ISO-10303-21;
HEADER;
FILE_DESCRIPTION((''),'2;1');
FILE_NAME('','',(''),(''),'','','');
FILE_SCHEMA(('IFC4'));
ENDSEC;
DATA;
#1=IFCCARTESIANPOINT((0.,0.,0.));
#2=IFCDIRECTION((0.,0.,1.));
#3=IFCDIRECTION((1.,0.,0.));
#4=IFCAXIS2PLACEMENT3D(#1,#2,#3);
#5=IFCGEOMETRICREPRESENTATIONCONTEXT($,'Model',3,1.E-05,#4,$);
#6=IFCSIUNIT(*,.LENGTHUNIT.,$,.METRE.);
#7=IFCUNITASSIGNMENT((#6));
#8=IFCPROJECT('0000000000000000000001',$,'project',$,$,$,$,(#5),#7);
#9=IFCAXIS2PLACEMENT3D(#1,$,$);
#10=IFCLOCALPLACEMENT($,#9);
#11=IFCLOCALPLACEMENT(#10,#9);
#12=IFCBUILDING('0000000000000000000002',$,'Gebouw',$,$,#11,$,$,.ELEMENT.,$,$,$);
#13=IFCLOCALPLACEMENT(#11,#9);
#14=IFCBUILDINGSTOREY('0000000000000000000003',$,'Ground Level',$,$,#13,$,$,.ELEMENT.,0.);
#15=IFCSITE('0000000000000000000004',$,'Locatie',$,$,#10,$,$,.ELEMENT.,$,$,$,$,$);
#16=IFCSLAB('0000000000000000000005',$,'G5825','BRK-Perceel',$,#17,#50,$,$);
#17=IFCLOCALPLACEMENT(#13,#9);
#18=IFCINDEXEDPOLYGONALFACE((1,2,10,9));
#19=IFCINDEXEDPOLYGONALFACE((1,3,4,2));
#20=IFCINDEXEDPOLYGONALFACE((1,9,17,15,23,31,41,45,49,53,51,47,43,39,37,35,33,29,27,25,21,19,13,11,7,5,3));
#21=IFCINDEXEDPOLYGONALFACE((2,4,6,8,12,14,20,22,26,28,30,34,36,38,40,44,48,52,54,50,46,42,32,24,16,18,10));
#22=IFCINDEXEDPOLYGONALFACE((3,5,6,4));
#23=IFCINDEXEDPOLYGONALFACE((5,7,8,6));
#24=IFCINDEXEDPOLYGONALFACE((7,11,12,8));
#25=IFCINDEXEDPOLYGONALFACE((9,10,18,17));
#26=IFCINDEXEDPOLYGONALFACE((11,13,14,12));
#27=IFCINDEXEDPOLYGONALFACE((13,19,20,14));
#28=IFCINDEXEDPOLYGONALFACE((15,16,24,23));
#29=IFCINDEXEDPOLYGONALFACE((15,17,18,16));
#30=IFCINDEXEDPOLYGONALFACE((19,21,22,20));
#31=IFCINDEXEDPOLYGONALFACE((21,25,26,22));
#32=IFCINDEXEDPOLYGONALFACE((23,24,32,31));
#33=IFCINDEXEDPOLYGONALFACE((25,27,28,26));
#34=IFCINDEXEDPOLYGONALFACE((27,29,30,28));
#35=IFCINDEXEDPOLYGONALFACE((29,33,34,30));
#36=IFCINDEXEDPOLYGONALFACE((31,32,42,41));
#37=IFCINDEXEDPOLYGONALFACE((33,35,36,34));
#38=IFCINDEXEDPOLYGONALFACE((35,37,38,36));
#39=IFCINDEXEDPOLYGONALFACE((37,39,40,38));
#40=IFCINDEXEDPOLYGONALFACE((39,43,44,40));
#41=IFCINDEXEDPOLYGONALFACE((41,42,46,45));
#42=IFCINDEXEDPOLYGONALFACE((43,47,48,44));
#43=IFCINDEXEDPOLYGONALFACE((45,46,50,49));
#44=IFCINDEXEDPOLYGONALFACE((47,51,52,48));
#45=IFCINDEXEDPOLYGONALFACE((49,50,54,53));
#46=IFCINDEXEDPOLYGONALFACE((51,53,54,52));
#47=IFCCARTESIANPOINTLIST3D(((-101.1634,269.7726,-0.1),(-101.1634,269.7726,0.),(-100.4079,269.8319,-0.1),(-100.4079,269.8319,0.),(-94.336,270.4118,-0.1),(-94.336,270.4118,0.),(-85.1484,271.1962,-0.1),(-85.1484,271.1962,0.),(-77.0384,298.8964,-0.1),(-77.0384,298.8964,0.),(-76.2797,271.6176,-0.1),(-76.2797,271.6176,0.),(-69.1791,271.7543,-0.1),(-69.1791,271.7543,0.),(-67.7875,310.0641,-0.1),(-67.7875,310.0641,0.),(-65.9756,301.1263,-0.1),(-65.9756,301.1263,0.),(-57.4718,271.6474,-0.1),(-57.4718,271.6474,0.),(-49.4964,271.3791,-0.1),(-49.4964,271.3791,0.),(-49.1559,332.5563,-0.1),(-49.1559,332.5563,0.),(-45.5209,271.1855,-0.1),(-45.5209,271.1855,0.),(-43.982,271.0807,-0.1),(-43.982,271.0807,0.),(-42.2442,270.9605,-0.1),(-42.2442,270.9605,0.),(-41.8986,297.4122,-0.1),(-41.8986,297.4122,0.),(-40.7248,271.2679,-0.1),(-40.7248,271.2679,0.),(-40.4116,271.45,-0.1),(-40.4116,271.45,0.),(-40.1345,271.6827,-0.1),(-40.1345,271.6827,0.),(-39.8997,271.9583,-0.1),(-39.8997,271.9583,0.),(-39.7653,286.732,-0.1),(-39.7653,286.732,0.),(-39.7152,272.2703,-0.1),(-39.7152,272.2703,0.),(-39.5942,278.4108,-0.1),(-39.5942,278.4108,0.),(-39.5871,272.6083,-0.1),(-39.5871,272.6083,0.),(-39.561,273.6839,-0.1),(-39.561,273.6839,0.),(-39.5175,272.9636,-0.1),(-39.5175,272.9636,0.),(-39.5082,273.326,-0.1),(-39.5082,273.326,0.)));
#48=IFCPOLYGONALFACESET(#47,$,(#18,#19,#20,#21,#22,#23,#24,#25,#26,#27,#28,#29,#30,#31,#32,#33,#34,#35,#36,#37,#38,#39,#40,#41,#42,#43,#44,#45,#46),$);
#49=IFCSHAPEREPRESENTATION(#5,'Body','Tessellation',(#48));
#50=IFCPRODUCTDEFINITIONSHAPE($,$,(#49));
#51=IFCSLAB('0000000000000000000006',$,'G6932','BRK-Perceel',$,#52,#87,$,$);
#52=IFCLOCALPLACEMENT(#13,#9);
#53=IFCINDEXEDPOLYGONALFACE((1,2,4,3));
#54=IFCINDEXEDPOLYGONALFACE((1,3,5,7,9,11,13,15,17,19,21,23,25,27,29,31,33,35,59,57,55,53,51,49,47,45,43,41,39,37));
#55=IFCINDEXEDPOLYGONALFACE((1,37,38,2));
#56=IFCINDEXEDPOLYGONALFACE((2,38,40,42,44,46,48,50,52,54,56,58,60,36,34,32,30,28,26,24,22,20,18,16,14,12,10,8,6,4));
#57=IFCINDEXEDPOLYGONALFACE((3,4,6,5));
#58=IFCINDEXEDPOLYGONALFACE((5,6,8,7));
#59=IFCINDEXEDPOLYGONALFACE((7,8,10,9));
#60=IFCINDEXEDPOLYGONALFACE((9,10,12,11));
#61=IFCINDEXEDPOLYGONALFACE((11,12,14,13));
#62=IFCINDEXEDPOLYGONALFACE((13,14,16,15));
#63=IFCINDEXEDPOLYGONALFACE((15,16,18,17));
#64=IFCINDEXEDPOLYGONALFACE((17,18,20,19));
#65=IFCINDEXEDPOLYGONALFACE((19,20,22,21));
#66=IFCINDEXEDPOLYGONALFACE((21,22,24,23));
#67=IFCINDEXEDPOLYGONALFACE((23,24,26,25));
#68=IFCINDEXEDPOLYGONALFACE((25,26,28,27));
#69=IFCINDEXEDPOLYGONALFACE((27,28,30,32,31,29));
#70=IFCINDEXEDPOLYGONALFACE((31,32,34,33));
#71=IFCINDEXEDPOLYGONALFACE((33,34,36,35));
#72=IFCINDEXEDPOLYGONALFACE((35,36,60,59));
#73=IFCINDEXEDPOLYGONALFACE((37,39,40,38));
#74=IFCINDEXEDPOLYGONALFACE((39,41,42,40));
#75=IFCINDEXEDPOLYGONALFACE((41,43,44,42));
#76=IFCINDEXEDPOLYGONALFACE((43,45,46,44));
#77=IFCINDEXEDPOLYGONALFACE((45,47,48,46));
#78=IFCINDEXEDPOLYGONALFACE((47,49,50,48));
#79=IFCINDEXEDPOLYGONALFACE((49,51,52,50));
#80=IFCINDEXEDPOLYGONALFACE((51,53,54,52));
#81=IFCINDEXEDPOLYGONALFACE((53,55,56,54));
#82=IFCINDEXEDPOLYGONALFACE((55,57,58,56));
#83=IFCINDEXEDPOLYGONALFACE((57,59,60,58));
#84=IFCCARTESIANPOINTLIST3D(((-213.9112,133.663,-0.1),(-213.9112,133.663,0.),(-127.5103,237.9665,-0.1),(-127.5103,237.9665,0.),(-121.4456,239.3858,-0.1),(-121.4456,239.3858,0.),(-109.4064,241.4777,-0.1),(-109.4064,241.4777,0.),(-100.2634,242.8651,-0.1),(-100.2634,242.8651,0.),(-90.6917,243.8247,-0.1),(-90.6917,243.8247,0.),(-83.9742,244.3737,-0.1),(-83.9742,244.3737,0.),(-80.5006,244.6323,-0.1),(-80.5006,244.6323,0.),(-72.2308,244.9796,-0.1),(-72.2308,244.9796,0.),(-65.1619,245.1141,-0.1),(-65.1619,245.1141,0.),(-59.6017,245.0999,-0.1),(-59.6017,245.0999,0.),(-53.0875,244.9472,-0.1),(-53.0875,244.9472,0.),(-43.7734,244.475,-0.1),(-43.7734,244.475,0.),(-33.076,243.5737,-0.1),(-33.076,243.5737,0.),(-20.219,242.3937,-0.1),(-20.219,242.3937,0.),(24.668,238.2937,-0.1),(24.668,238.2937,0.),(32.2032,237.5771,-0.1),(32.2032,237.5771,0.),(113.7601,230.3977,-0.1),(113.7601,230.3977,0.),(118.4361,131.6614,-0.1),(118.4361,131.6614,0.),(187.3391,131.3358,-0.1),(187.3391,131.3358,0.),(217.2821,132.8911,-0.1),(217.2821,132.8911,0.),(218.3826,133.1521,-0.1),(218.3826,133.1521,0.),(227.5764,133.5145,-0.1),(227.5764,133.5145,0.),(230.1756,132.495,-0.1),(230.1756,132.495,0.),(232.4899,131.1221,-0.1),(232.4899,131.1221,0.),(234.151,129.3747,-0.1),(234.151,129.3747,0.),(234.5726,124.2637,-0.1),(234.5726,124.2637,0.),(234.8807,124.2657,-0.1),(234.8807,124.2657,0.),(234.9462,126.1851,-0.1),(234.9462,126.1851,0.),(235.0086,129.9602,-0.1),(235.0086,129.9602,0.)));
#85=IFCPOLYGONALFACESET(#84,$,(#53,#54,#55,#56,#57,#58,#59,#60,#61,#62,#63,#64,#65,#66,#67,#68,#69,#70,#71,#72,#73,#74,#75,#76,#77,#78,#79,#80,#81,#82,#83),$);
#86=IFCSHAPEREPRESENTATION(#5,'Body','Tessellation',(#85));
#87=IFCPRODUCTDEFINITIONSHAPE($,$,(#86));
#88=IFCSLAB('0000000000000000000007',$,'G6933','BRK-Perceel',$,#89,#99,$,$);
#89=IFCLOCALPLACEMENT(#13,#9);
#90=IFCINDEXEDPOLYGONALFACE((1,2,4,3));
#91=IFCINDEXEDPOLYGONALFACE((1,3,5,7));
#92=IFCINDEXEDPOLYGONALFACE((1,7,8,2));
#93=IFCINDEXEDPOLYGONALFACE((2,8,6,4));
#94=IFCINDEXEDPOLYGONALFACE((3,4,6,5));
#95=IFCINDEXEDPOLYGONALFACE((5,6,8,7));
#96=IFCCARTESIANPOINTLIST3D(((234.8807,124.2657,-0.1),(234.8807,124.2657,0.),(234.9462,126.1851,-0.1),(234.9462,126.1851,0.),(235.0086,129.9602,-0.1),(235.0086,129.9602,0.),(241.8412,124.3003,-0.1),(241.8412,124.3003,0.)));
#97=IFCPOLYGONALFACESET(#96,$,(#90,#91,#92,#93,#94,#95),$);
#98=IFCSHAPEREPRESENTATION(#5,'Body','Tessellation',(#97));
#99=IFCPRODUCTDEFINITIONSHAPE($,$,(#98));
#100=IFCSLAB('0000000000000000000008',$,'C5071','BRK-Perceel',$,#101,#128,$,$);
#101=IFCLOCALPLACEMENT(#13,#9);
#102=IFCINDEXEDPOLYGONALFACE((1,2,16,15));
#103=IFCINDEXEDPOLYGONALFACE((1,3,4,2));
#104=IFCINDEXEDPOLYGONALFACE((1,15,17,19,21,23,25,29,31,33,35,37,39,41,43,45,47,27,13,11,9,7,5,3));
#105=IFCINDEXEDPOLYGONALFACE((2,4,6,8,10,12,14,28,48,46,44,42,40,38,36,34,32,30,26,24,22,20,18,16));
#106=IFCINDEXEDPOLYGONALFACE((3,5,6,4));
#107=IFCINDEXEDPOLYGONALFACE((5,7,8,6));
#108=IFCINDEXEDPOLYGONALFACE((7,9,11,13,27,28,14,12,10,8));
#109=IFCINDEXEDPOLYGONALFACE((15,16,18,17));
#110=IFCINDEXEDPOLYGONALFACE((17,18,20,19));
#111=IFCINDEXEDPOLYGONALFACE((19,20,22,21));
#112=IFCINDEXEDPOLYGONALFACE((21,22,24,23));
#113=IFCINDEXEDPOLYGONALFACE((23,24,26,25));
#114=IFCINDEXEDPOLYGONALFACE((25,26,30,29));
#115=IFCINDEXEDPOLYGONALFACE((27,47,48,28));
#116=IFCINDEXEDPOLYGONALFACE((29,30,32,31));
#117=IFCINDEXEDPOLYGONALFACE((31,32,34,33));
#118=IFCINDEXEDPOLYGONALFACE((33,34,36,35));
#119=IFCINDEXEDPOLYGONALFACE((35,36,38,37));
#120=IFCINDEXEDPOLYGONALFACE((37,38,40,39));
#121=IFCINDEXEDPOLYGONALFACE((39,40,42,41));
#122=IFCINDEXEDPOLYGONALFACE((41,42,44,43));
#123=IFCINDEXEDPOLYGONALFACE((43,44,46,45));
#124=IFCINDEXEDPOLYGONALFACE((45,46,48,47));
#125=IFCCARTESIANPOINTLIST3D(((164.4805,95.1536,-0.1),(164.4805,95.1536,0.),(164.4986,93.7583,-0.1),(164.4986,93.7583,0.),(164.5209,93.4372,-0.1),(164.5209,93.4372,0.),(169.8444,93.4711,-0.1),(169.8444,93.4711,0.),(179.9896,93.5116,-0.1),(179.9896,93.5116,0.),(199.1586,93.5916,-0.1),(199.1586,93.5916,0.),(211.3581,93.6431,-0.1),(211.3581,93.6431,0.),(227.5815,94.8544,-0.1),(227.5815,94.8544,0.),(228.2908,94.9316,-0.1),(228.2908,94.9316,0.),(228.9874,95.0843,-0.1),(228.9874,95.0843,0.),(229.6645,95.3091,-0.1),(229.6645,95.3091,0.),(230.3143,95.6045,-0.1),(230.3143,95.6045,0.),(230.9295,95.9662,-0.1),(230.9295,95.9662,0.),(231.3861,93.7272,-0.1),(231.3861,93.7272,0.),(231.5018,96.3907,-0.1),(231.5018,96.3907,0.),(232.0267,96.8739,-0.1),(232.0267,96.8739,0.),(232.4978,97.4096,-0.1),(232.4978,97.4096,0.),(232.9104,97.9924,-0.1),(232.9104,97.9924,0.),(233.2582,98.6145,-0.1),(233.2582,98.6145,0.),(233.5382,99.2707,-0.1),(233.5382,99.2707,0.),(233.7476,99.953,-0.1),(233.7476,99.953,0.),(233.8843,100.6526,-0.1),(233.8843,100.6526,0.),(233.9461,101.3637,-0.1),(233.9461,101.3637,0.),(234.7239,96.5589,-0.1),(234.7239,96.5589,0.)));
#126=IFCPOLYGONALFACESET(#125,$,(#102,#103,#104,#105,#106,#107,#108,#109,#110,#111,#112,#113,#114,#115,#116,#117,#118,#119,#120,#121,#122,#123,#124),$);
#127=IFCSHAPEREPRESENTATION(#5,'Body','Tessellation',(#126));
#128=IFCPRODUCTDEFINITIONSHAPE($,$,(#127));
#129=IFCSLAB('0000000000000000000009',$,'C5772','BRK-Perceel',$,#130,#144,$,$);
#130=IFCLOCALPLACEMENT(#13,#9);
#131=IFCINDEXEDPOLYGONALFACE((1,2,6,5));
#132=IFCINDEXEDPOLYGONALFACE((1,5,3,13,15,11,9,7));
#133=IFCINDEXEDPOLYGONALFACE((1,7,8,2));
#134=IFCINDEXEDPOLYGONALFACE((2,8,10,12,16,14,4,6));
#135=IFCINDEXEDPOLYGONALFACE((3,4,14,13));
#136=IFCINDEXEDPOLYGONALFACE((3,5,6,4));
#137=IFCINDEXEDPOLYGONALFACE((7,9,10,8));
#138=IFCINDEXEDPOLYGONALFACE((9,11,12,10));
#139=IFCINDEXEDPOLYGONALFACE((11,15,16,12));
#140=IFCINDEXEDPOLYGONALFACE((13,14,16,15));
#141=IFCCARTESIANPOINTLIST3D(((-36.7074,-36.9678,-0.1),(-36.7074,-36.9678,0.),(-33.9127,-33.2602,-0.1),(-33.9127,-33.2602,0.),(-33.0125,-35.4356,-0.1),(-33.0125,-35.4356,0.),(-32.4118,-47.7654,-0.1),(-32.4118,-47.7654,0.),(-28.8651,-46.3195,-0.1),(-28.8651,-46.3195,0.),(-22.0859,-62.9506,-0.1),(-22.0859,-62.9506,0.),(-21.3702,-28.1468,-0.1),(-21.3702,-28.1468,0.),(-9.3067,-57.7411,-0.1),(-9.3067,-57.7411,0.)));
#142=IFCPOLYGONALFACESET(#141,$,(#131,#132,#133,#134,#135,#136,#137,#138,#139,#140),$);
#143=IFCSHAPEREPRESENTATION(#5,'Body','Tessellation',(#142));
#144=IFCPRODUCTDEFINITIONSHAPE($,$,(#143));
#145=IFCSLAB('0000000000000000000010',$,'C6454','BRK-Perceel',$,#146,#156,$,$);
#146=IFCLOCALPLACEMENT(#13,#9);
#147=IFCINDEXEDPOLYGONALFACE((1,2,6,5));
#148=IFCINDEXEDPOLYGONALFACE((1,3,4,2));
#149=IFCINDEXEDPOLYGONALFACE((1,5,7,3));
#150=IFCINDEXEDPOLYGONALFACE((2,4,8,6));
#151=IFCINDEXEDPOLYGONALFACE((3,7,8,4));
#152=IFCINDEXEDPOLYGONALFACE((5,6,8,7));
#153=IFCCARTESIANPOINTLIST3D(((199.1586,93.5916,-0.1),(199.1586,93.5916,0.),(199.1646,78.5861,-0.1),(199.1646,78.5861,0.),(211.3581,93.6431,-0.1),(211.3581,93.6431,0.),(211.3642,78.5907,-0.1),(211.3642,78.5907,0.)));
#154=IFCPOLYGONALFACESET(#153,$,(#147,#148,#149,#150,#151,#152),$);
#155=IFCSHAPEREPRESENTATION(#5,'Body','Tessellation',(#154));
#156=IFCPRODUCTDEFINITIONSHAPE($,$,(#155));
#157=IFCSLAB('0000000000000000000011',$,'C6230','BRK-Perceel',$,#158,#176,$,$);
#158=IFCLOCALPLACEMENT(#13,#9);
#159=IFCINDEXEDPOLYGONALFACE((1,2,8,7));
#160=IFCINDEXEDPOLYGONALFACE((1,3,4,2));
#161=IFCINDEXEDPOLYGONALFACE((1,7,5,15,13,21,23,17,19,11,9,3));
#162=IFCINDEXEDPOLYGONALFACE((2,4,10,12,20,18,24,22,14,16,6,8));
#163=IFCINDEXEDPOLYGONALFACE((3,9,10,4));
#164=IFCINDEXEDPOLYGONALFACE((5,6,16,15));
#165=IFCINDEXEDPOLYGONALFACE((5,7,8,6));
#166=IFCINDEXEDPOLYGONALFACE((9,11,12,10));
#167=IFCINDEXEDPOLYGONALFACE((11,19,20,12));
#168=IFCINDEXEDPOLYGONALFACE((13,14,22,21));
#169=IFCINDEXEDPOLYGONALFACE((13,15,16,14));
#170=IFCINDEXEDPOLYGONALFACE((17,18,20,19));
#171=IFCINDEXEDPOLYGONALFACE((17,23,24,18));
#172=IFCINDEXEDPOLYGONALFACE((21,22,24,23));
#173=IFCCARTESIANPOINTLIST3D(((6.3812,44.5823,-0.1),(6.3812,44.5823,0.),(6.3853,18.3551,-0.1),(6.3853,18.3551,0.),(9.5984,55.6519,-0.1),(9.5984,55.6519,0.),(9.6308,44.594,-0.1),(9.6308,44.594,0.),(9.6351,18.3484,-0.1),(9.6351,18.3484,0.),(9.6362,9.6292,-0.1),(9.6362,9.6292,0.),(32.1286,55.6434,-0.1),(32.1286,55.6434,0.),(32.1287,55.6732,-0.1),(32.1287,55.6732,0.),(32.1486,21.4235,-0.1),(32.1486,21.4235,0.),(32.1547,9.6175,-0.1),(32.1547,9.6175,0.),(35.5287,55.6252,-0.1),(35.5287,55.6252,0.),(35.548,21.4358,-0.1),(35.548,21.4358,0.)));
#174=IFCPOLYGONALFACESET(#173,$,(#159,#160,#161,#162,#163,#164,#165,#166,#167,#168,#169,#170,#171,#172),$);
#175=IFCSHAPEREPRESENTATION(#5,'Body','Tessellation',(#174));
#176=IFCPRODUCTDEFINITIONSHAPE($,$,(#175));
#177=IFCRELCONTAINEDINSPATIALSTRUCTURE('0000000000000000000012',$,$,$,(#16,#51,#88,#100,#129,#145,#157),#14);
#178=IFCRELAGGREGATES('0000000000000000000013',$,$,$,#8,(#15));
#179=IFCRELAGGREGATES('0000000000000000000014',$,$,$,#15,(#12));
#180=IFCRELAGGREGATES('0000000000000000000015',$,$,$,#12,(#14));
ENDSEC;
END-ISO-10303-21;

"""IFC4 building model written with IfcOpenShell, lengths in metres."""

from ifc_helpers import new_model, si_unit, frame, origin, origin_with_axes, place, context, project, spatial, polyline, outline, extrude, element, save


model = new_model("IFC4")

# Units and contexts
model_context = context("Model", 3, precision=1e-05, world=origin_with_axes())
ifc_project = project(units=[si_unit("LENGTHUNIT", "METRE")], contexts=[model_context])

# Site, building, storey
site_placement = place(None, origin())
site = spatial("IfcSite", under=ifc_project, at=site_placement, Name="Locatie", CompositionType="ELEMENT")
building_placement = place(site_placement, origin())
building = spatial("IfcBuilding", under=site, at=building_placement, Name="Gebouw", CompositionType="ELEMENT")
storey_placement = place(building_placement, origin())
storey = spatial("IfcBuildingStorey", under=building, at=storey_placement, Name="Ground Level", CompositionType="ELEMENT", Elevation=0.0)

# Slabs
slab_1_placement = place(storey_placement, origin())
element("IfcSlab", 1, at=slab_1_placement, inside=storey, Name="G5825", Description="BRK-Perceel", context=model_context, shape_type="SweptSolid", body=[
    extrude(outline(polyline([(-65.9756, 301.1263), (-67.7875, 310.0641), (-49.1559, 332.5563), (-41.8986, 297.4122), (-39.7653, 286.732), (-39.5942, 278.4108), (-39.561, 273.6839), (-39.5082, 273.326), (-39.5175, 272.9636), (-39.5871, 272.6083), (-39.7152, 272.2703), (-39.8997, 271.9583), (-40.1345, 271.6827), (-40.4116, 271.45), (-40.7248, 271.2679), (-42.2442, 270.9605), (-43.982, 271.0807), (-45.5209, 271.1855), (-49.4964, 271.3791), (-57.4718, 271.6474), (-69.1791, 271.7543), (-76.2797, 271.6176), (-85.1484, 271.1962), (-94.336, 270.4118), (-100.4079, 269.8319), (-101.1634, 269.7726), (-77.0384, 298.8964), (-65.9756, 301.1263)])), frame((0.0, 0.0, -0.1), z_axis=(0.0, 0.0, 1.0), x_axis=(1.0, 0.0, 0.0)), (0.0, 0.0, 1.0), 0.1),
])
slab_2_placement = place(storey_placement, origin())
element("IfcSlab", 2, at=slab_2_placement, inside=storey, Name="G6932", Description="BRK-Perceel", context=model_context, shape_type="SweptSolid", body=[
    extrude(outline(polyline([(234.9462, 126.1851), (234.8807, 124.2657), (234.5726, 124.2637), (234.151, 129.3747), (232.4899, 131.1221), (230.1756, 132.495), (227.5764, 133.5145), (218.3826, 133.1521), (217.2821, 132.8911), (187.3391, 131.3358), (118.4361, 131.6614), (-213.9112, 133.663), (-127.5103, 237.9665), (-121.4456, 239.3858), (-109.4064, 241.4777), (-100.2634, 242.8651), (-90.6917, 243.8247), (-83.9742, 244.3737), (-80.5006, 244.6323), (-72.2308, 244.9796), (-65.1619, 245.1141), (-59.6017, 245.0999), (-53.0875, 244.9472), (-43.7734, 244.475), (-33.076, 243.5737), (-20.219, 242.3937), (24.668, 238.2937), (32.2032, 237.5771), (113.7601, 230.3977), (235.0086, 129.9602), (234.9462, 126.1851)])), frame((0.0, 0.0, -0.1), z_axis=(0.0, 0.0, 1.0), x_axis=(1.0, 0.0, 0.0)), (0.0, 0.0, 1.0), 0.1),
])
slab_3_placement = place(storey_placement, origin())
element("IfcSlab", 3, at=slab_3_placement, inside=storey, Name="G6933", Description="BRK-Perceel", context=model_context, shape_type="SweptSolid", body=[
    extrude(outline(polyline([(234.8807, 124.2657), (234.9462, 126.1851), (235.0086, 129.9602), (241.8412, 124.3003), (234.8807, 124.2657)])), frame((0.0, 0.0, -0.1), z_axis=(0.0, 0.0, 1.0), x_axis=(1.0, 0.0, 0.0)), (0.0, 0.0, 1.0), 0.1),
])
slab_4_placement = place(storey_placement, origin())
element("IfcSlab", 4, at=slab_4_placement, inside=storey, Name="C5071", Description="BRK-Perceel", context=model_context, shape_type="SweptSolid", body=[
    extrude(outline(polyline([(228.2908, 94.9316), (228.9874, 95.0843), (229.6645, 95.3091), (230.3143, 95.6045), (230.9295, 95.9662), (231.5018, 96.3907), (232.0267, 96.8739), (232.4978, 97.4096), (232.9104, 97.9924), (233.2582, 98.6145), (233.5382, 99.2707), (233.7476, 99.953), (233.8843, 100.6526), (233.9461, 101.3637), (234.7239, 96.5589), (231.3861, 93.7272), (211.3581, 93.6431), (199.1586, 93.5916), (179.9896, 93.5116), (169.8444, 93.4711), (164.5209, 93.4372), (164.4986, 93.7583), (164.4805, 95.1536), (227.5815, 94.8544), (228.2908, 94.9316)])), frame((0.0, 0.0, -0.1), z_axis=(0.0, 0.0, 1.0), x_axis=(1.0, 0.0, 0.0)), (0.0, 0.0, 1.0), 0.1),
])
slab_5_placement = place(storey_placement, origin())
element("IfcSlab", 5, at=slab_5_placement, inside=storey, Name="C5772", Description="BRK-Perceel", context=model_context, shape_type="SweptSolid", body=[
    extrude(outline(polyline([(-21.3702, -28.1468), (-9.3067, -57.7411), (-22.0859, -62.9506), (-28.8651, -46.3195), (-32.4118, -47.7654), (-36.7074, -36.9678), (-33.0125, -35.4356), (-33.9127, -33.2602), (-21.3702, -28.1468)])), frame((0.0, 0.0, -0.1), z_axis=(0.0, 0.0, 1.0), x_axis=(1.0, 0.0, 0.0)), (0.0, 0.0, 1.0), 0.1),
])
slab_6_placement = place(storey_placement, origin())
element("IfcSlab", 6, at=slab_6_placement, inside=storey, Name="C6454", Description="BRK-Perceel", context=model_context, shape_type="SweptSolid", body=[
    extrude(outline(polyline([(211.3581, 93.6431), (211.3642, 78.5907), (199.1646, 78.5861), (199.1586, 93.5916), (211.3581, 93.6431)])), frame((0.0, 0.0, -0.1), z_axis=(0.0, 0.0, 1.0), x_axis=(1.0, 0.0, 0.0)), (0.0, 0.0, 1.0), 0.1),
])
slab_7_placement = place(storey_placement, origin())
element("IfcSlab", 7, at=slab_7_placement, inside=storey, Name="C6230", Description="BRK-Perceel", context=model_context, shape_type="SweptSolid", body=[
    extrude(outline(polyline([(9.6362, 9.6292), (9.6351, 18.3484), (6.3853, 18.3551), (6.3812, 44.5823), (9.6308, 44.594), (9.5984, 55.6519), (32.1287, 55.6732), (32.1286, 55.6434), (35.5287, 55.6252), (35.548, 21.4358), (32.1486, 21.4235), (32.1547, 9.6175), (9.6362, 9.6292)])), frame((0.0, 0.0, -0.1), z_axis=(0.0, 0.0, 1.0), x_axis=(1.0, 0.0, 0.0)), (0.0, 0.0, 1.0), 0.1),
])

save(model, "model.ifc")
